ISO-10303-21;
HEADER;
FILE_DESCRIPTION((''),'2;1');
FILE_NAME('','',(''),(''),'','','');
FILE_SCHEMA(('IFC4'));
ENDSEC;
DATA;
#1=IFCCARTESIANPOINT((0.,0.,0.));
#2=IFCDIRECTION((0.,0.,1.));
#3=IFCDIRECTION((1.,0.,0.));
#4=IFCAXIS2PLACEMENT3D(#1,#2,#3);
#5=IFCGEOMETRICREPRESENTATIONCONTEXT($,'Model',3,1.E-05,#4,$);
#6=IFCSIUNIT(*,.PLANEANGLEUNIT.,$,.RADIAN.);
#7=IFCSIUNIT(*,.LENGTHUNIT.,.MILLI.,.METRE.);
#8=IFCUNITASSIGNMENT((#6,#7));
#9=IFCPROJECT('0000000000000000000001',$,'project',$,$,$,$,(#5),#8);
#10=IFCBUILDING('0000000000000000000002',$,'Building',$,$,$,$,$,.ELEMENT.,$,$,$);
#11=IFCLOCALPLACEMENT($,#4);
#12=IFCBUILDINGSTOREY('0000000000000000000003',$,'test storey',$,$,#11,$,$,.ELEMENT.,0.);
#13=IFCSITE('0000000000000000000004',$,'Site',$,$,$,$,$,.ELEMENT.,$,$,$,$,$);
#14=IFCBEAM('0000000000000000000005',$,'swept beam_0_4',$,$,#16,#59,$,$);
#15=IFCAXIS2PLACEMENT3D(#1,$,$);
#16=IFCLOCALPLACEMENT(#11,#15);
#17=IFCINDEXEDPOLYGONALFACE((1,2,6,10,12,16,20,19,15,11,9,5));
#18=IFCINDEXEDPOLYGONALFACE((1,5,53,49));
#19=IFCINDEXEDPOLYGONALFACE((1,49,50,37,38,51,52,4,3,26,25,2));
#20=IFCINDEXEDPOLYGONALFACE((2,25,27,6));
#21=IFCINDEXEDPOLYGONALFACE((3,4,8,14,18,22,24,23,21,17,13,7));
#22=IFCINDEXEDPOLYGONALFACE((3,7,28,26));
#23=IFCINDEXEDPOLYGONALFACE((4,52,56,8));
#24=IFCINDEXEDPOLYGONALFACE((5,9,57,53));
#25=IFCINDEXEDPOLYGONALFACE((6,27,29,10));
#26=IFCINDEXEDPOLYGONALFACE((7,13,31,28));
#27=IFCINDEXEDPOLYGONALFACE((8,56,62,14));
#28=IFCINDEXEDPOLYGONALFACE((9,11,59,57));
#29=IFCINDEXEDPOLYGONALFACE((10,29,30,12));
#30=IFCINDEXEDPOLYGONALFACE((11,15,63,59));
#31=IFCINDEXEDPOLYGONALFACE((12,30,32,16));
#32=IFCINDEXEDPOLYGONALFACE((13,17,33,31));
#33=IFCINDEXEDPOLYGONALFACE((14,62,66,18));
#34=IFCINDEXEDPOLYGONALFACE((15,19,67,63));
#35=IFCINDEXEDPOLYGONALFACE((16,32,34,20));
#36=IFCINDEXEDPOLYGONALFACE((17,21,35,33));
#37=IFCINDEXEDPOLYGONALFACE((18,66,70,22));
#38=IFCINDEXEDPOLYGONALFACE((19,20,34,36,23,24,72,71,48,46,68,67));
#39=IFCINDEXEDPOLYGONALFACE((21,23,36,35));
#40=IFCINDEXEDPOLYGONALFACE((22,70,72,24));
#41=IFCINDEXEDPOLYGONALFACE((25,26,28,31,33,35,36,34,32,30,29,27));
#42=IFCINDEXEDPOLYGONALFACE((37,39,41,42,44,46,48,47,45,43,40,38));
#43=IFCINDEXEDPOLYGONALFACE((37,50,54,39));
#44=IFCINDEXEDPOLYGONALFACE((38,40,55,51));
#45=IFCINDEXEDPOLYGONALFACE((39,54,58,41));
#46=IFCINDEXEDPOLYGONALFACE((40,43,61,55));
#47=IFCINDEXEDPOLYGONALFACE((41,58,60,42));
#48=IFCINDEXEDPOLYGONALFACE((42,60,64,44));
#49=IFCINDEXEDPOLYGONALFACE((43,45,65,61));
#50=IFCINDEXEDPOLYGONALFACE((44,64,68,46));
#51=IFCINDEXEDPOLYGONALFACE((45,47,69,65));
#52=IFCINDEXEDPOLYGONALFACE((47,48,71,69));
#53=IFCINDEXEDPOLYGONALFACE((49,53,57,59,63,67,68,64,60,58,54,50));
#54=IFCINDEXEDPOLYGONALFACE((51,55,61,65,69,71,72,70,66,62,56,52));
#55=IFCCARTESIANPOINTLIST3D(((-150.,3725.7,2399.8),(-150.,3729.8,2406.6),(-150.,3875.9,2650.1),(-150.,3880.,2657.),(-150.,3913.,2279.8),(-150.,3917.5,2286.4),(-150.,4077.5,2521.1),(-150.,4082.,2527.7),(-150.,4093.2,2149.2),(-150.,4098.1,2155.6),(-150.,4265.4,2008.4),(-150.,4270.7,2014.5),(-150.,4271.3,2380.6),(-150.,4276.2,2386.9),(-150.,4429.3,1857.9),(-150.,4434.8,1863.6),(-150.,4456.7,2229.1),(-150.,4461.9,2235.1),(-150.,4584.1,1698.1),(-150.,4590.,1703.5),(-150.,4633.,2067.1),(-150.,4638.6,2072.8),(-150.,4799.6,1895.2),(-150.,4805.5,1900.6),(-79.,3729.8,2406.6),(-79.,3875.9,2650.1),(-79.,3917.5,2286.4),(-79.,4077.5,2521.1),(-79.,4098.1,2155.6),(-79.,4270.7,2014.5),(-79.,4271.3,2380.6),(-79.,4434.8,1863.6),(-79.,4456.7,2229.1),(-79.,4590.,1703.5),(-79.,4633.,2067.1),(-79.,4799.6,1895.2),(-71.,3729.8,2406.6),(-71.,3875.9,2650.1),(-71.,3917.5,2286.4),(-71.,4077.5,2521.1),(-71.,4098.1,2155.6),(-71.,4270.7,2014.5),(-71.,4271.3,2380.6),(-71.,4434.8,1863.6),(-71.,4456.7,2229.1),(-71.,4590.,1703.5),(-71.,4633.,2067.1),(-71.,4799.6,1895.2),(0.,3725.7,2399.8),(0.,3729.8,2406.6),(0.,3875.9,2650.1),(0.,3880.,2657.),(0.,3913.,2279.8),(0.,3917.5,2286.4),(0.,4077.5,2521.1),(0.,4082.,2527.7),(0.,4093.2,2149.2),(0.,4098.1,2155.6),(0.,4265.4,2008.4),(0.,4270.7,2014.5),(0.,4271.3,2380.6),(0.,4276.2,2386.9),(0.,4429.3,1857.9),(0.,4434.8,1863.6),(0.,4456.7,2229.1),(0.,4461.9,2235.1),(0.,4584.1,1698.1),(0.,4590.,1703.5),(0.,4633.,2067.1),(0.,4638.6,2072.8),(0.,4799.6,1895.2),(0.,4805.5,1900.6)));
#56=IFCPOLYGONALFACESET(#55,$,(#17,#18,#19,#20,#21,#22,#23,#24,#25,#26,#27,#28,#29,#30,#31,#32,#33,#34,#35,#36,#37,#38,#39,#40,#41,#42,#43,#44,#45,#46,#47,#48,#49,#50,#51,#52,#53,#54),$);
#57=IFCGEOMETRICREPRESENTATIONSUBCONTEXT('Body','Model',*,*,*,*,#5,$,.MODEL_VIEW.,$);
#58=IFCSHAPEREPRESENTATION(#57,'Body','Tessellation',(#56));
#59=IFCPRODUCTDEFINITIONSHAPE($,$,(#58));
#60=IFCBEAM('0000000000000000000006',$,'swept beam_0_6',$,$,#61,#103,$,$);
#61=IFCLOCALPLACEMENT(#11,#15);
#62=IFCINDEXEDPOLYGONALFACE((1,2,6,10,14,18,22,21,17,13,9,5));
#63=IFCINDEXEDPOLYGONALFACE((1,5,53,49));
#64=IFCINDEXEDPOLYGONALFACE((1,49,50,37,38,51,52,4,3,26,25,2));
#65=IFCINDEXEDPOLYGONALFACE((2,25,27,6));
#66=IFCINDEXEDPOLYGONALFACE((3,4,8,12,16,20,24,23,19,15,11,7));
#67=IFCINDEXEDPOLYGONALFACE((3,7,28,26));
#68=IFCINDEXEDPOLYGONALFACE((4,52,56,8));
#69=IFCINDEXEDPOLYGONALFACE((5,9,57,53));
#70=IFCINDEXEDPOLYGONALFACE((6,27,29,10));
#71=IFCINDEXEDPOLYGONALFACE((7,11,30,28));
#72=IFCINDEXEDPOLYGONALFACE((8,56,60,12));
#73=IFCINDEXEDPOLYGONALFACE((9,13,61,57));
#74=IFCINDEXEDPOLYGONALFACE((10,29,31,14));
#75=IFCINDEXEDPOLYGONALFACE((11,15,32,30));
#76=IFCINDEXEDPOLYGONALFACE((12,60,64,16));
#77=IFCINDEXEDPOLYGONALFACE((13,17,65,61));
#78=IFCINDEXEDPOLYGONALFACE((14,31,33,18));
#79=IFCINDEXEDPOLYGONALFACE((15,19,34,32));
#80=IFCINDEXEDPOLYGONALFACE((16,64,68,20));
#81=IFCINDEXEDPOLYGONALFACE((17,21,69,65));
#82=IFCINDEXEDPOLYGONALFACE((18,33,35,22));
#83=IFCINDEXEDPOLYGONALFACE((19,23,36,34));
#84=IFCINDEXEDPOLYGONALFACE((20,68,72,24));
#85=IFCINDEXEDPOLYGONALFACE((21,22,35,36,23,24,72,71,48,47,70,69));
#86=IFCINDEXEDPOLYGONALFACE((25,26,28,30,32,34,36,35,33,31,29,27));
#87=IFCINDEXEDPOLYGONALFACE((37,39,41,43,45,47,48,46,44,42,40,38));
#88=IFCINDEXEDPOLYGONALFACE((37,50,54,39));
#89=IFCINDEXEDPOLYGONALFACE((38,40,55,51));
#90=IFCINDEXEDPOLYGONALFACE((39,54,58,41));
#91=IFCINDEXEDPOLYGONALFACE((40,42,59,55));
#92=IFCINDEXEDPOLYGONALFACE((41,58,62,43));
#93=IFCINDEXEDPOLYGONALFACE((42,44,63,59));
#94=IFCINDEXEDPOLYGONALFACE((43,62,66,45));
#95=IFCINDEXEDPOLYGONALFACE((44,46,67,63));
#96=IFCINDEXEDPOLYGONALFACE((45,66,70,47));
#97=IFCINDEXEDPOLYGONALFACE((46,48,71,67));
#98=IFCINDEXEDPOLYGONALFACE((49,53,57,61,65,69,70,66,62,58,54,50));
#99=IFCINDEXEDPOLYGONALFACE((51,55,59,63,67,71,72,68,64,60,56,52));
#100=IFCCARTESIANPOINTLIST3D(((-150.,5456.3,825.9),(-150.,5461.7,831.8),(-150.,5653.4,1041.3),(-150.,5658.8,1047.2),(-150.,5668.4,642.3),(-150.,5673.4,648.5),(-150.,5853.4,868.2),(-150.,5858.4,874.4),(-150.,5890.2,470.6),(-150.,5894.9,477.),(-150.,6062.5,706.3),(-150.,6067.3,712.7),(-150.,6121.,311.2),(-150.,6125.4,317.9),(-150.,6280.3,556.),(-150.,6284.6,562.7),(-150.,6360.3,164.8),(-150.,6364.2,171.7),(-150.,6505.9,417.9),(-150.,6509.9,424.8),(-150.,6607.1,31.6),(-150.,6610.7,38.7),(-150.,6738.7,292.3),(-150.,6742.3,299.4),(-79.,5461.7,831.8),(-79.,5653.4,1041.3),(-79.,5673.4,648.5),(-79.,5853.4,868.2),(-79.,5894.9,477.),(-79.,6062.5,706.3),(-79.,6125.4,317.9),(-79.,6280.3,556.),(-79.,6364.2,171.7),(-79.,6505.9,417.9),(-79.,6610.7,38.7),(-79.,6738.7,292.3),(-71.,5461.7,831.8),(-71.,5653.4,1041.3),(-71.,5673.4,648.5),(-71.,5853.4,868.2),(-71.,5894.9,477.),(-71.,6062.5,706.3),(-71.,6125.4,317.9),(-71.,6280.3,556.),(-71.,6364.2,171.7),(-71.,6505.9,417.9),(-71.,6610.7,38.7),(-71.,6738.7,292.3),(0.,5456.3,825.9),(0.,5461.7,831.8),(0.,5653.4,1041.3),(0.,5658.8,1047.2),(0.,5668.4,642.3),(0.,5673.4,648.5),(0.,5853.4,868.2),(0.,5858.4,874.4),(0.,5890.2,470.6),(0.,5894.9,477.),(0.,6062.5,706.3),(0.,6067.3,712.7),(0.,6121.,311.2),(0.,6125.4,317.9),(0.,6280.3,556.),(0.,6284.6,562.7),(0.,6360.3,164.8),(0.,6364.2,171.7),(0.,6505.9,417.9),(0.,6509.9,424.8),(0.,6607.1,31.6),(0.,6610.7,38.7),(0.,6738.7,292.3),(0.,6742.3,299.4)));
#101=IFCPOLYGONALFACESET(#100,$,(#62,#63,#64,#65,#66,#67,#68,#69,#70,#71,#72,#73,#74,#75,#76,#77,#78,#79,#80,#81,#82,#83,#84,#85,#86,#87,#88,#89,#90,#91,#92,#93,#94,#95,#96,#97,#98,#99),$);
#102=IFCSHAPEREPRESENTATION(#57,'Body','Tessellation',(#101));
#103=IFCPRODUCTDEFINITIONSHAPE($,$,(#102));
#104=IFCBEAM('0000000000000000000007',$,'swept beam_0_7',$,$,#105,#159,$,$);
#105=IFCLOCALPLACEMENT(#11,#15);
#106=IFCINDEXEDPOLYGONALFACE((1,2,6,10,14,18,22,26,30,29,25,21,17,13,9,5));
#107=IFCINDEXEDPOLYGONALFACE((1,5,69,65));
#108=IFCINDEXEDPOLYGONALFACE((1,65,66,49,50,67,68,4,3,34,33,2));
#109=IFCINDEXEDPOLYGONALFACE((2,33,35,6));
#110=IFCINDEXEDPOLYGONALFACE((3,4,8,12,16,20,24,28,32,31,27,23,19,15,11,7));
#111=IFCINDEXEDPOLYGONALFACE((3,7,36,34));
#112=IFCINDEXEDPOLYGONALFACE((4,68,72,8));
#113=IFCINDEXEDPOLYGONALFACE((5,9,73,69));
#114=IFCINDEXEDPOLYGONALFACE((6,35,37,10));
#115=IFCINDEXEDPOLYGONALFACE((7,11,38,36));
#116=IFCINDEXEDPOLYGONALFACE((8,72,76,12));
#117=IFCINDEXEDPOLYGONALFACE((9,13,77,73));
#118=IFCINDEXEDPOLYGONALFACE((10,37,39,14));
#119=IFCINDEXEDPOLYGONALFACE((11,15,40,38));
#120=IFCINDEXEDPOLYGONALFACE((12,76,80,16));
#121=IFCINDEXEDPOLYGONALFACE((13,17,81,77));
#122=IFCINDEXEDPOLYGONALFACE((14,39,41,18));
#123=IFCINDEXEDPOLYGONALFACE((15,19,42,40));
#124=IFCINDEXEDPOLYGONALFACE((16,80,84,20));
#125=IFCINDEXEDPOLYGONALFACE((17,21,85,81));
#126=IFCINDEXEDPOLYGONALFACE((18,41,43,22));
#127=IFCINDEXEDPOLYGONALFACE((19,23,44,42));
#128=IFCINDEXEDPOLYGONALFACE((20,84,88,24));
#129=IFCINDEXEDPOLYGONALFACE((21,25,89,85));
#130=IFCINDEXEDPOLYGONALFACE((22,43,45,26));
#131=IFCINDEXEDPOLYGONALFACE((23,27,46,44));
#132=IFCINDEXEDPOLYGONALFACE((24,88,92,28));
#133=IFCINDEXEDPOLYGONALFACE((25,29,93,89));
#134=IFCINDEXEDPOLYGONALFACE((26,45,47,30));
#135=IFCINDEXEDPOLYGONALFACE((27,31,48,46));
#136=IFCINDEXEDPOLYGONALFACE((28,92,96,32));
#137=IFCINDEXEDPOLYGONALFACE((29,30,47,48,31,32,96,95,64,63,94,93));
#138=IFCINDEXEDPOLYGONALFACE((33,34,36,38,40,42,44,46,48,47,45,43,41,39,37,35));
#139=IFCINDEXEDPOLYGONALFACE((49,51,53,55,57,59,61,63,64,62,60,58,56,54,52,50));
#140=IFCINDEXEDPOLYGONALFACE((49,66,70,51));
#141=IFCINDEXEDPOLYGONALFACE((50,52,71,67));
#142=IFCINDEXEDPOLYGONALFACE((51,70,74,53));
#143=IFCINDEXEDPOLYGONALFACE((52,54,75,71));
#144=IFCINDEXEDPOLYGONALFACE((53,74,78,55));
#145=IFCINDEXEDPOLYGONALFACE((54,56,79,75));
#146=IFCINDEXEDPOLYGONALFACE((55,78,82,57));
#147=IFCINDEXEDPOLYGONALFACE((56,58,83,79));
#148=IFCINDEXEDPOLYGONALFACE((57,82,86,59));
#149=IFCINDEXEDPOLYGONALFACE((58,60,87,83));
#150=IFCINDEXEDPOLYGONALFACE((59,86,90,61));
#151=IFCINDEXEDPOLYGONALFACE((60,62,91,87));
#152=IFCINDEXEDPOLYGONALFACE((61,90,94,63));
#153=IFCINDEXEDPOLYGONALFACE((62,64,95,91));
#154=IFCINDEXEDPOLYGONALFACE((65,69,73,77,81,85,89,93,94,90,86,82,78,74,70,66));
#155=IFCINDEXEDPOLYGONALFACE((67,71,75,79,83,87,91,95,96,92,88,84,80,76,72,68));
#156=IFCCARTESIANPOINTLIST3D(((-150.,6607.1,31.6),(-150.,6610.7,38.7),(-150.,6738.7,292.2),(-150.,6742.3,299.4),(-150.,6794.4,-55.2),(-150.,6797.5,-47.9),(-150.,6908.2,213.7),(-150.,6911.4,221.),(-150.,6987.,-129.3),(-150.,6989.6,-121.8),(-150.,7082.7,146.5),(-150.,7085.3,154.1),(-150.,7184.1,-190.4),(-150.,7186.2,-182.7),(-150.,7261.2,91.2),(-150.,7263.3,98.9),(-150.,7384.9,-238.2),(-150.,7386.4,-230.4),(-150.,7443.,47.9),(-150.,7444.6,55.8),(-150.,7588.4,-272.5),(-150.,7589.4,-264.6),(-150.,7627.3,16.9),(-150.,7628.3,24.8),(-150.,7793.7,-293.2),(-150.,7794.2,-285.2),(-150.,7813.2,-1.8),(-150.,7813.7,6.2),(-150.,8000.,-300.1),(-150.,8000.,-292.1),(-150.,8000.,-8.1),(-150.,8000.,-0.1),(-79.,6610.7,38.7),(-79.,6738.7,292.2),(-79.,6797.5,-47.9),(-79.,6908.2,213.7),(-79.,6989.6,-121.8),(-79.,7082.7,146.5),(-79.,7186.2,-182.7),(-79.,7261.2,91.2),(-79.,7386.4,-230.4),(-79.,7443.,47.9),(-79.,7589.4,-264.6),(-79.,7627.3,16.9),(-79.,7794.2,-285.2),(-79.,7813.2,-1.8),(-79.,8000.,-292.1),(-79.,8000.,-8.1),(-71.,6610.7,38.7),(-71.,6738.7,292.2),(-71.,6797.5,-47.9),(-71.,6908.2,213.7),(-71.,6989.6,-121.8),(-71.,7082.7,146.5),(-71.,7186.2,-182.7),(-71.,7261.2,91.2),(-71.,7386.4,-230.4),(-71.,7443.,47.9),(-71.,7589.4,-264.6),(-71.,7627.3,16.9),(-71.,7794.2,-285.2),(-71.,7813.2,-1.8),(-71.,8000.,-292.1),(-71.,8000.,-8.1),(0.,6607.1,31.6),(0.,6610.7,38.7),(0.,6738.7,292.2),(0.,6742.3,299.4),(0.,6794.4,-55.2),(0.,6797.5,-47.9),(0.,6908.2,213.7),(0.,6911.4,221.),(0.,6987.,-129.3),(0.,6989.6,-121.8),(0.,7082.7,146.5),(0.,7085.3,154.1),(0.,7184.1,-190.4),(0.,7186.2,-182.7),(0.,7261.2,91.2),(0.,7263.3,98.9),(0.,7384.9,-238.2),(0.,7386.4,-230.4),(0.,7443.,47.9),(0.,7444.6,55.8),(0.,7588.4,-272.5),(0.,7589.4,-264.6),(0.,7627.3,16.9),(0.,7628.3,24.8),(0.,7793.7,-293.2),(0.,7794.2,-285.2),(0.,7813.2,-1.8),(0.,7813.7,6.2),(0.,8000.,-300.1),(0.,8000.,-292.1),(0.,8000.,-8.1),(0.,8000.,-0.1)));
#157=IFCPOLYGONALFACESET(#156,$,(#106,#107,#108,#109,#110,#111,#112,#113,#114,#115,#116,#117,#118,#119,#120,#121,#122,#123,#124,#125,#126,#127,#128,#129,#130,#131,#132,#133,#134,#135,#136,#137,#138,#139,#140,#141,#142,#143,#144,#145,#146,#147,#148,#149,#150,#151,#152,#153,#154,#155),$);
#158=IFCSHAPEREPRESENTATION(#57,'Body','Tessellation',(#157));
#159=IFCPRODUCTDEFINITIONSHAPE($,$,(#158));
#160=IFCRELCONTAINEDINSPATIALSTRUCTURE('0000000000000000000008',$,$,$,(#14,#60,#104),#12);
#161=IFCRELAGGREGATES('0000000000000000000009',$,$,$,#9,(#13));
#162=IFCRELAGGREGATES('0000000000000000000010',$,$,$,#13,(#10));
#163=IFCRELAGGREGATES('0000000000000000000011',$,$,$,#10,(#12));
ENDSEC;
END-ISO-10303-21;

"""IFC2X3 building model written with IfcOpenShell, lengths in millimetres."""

from ifc_helpers import new_model, entity, si_unit, origin_with_axes, place, context, subcontext, project, spatial, element, save


model = new_model("IFC2X3")

# Units and contexts
model_context = context("Model", 3, precision=1e-05, world=origin_with_axes())
body_context = subcontext(model_context, "Body", "Model", "MODEL_VIEW")
ifc_project = project(units=[si_unit("PLANEANGLEUNIT", "RADIAN"), si_unit("LENGTHUNIT", "METRE", prefix="MILLI")], contexts=[model_context])

# Site, building, storey
site = spatial("IfcSite", under=ifc_project, Name="Site", CompositionType="ELEMENT")
building = spatial("IfcBuilding", under=site, Name="Building", CompositionType="ELEMENT")
storey_placement = place(None, origin_with_axes())
storey = spatial("IfcBuildingStorey", under=building, at=storey_placement, Name="test storey", CompositionType="ELEMENT", Elevation=0.0)

# Beams
beam_1_placement = place(storey_placement, origin_with_axes())
element("IfcBeam", 1, at=beam_1_placement, inside=storey, Name="swept beam_0_4", context=body_context, shape_type="SweptSolid", body=[
    entity("IfcRevolvedAreaSolid", entity("IfcArbitraryClosedProfileDef", "AREA", None, entity("IfcPolyline", [entity("IfcCartesianPoint", [-292.0, 0.0]), entity("IfcCartesianPoint", [-292.0, 71.0]), entity("IfcCartesianPoint", [-8.0, 71.0]), entity("IfcCartesianPoint", [-8.0, 0.0]), entity("IfcCartesianPoint", [0.0, 0.0]), entity("IfcCartesianPoint", [0.0, 150.0]), entity("IfcCartesianPoint", [-8.0, 150.0]), entity("IfcCartesianPoint", [-8.0, 79.0]), entity("IfcCartesianPoint", [-292.0, 79.0]), entity("IfcCartesianPoint", [-292.0, 150.0]), entity("IfcCartesianPoint", [-300.0, 150.0]), entity("IfcCartesianPoint", [-300.0, 0.0]), entity("IfcCartesianPoint", [-292.0, 0.0])])), entity("IfcAxis2Placement3D", entity("IfcCartesianPoint", [0.0, 3880.0, 2657.0]), entity("IfcDirection", [0.0, -0.8575, 0.5145]), entity("IfcDirection", [0.0, 0.5145, 0.8575])), entity("IfcAxis1Placement", entity("IfcCartesianPoint", [-4141.8, 0.0, 0.0]), entity("IfcDirection", [0.0, 1.0, 0.0])), 0.289603),
])
beam_2_placement = place(storey_placement, origin_with_axes())
element("IfcBeam", 2, at=beam_2_placement, inside=storey, Name="swept beam_0_6", context=body_context, shape_type="SweptSolid", body=[
    entity("IfcRevolvedAreaSolid", entity("IfcArbitraryClosedProfileDef", "AREA", None, entity("IfcPolyline", [entity("IfcCartesianPoint", [292.0, 0.0]), entity("IfcCartesianPoint", [292.0, -71.0]), entity("IfcCartesianPoint", [8.0, -71.0]), entity("IfcCartesianPoint", [8.0, 0.0]), entity("IfcCartesianPoint", [0.0, 0.0]), entity("IfcCartesianPoint", [0.0, -150.0]), entity("IfcCartesianPoint", [8.0, -150.0]), entity("IfcCartesianPoint", [8.0, -79.0]), entity("IfcCartesianPoint", [292.0, -79.0]), entity("IfcCartesianPoint", [292.0, -150.0]), entity("IfcCartesianPoint", [300.0, -150.0]), entity("IfcCartesianPoint", [300.0, 0.0]), entity("IfcCartesianPoint", [292.0, 0.0])])), entity("IfcAxis2Placement3D", entity("IfcCartesianPoint", [0.0, 5658.8, 1047.2]), entity("IfcDirection", [0.0, -0.7379, 0.6749]), entity("IfcDirection", [0.0, -0.6749, -0.7379])), entity("IfcAxis1Placement", entity("IfcCartesianPoint", [-4829.8, 0.0, 0.0]), entity("IfcDirection", [0.0, 1.0, 0.0])), 0.273446),
])
beam_3_placement = place(storey_placement, origin_with_axes())
element("IfcBeam", 3, at=beam_3_placement, inside=storey, Name="swept beam_0_7", context=body_context, shape_type="SweptSolid", body=[
    entity("IfcRevolvedAreaSolid", entity("IfcArbitraryClosedProfileDef", "AREA", None, entity("IfcPolyline", [entity("IfcCartesianPoint", [292.0, 0.0]), entity("IfcCartesianPoint", [292.0, -71.0]), entity("IfcCartesianPoint", [8.0, -71.0]), entity("IfcCartesianPoint", [8.0, 0.0]), entity("IfcCartesianPoint", [0.0, 0.0]), entity("IfcCartesianPoint", [0.0, -150.0]), entity("IfcCartesianPoint", [8.0, -150.0]), entity("IfcCartesianPoint", [8.0, -79.0]), entity("IfcCartesianPoint", [292.0, -79.0]), entity("IfcCartesianPoint", [292.0, -150.0]), entity("IfcCartesianPoint", [300.0, -150.0]), entity("IfcCartesianPoint", [300.0, 0.0]), entity("IfcCartesianPoint", [292.0, 0.0])])), entity("IfcAxis2Placement3D", entity("IfcCartesianPoint", [0.0, 6742.3, 299.4]), entity("IfcDirection", [0.0, -0.8927, 0.4506]), entity("IfcDirection", [0.0, -0.4506, -0.8927])), entity("IfcAxis1Placement", entity("IfcCartesianPoint", [-2791.4, 0.0, 0.0]), entity("IfcDirection", [0.0, 1.0, 0.0])), 0.467393),
])

save(model, "model.ifc")
